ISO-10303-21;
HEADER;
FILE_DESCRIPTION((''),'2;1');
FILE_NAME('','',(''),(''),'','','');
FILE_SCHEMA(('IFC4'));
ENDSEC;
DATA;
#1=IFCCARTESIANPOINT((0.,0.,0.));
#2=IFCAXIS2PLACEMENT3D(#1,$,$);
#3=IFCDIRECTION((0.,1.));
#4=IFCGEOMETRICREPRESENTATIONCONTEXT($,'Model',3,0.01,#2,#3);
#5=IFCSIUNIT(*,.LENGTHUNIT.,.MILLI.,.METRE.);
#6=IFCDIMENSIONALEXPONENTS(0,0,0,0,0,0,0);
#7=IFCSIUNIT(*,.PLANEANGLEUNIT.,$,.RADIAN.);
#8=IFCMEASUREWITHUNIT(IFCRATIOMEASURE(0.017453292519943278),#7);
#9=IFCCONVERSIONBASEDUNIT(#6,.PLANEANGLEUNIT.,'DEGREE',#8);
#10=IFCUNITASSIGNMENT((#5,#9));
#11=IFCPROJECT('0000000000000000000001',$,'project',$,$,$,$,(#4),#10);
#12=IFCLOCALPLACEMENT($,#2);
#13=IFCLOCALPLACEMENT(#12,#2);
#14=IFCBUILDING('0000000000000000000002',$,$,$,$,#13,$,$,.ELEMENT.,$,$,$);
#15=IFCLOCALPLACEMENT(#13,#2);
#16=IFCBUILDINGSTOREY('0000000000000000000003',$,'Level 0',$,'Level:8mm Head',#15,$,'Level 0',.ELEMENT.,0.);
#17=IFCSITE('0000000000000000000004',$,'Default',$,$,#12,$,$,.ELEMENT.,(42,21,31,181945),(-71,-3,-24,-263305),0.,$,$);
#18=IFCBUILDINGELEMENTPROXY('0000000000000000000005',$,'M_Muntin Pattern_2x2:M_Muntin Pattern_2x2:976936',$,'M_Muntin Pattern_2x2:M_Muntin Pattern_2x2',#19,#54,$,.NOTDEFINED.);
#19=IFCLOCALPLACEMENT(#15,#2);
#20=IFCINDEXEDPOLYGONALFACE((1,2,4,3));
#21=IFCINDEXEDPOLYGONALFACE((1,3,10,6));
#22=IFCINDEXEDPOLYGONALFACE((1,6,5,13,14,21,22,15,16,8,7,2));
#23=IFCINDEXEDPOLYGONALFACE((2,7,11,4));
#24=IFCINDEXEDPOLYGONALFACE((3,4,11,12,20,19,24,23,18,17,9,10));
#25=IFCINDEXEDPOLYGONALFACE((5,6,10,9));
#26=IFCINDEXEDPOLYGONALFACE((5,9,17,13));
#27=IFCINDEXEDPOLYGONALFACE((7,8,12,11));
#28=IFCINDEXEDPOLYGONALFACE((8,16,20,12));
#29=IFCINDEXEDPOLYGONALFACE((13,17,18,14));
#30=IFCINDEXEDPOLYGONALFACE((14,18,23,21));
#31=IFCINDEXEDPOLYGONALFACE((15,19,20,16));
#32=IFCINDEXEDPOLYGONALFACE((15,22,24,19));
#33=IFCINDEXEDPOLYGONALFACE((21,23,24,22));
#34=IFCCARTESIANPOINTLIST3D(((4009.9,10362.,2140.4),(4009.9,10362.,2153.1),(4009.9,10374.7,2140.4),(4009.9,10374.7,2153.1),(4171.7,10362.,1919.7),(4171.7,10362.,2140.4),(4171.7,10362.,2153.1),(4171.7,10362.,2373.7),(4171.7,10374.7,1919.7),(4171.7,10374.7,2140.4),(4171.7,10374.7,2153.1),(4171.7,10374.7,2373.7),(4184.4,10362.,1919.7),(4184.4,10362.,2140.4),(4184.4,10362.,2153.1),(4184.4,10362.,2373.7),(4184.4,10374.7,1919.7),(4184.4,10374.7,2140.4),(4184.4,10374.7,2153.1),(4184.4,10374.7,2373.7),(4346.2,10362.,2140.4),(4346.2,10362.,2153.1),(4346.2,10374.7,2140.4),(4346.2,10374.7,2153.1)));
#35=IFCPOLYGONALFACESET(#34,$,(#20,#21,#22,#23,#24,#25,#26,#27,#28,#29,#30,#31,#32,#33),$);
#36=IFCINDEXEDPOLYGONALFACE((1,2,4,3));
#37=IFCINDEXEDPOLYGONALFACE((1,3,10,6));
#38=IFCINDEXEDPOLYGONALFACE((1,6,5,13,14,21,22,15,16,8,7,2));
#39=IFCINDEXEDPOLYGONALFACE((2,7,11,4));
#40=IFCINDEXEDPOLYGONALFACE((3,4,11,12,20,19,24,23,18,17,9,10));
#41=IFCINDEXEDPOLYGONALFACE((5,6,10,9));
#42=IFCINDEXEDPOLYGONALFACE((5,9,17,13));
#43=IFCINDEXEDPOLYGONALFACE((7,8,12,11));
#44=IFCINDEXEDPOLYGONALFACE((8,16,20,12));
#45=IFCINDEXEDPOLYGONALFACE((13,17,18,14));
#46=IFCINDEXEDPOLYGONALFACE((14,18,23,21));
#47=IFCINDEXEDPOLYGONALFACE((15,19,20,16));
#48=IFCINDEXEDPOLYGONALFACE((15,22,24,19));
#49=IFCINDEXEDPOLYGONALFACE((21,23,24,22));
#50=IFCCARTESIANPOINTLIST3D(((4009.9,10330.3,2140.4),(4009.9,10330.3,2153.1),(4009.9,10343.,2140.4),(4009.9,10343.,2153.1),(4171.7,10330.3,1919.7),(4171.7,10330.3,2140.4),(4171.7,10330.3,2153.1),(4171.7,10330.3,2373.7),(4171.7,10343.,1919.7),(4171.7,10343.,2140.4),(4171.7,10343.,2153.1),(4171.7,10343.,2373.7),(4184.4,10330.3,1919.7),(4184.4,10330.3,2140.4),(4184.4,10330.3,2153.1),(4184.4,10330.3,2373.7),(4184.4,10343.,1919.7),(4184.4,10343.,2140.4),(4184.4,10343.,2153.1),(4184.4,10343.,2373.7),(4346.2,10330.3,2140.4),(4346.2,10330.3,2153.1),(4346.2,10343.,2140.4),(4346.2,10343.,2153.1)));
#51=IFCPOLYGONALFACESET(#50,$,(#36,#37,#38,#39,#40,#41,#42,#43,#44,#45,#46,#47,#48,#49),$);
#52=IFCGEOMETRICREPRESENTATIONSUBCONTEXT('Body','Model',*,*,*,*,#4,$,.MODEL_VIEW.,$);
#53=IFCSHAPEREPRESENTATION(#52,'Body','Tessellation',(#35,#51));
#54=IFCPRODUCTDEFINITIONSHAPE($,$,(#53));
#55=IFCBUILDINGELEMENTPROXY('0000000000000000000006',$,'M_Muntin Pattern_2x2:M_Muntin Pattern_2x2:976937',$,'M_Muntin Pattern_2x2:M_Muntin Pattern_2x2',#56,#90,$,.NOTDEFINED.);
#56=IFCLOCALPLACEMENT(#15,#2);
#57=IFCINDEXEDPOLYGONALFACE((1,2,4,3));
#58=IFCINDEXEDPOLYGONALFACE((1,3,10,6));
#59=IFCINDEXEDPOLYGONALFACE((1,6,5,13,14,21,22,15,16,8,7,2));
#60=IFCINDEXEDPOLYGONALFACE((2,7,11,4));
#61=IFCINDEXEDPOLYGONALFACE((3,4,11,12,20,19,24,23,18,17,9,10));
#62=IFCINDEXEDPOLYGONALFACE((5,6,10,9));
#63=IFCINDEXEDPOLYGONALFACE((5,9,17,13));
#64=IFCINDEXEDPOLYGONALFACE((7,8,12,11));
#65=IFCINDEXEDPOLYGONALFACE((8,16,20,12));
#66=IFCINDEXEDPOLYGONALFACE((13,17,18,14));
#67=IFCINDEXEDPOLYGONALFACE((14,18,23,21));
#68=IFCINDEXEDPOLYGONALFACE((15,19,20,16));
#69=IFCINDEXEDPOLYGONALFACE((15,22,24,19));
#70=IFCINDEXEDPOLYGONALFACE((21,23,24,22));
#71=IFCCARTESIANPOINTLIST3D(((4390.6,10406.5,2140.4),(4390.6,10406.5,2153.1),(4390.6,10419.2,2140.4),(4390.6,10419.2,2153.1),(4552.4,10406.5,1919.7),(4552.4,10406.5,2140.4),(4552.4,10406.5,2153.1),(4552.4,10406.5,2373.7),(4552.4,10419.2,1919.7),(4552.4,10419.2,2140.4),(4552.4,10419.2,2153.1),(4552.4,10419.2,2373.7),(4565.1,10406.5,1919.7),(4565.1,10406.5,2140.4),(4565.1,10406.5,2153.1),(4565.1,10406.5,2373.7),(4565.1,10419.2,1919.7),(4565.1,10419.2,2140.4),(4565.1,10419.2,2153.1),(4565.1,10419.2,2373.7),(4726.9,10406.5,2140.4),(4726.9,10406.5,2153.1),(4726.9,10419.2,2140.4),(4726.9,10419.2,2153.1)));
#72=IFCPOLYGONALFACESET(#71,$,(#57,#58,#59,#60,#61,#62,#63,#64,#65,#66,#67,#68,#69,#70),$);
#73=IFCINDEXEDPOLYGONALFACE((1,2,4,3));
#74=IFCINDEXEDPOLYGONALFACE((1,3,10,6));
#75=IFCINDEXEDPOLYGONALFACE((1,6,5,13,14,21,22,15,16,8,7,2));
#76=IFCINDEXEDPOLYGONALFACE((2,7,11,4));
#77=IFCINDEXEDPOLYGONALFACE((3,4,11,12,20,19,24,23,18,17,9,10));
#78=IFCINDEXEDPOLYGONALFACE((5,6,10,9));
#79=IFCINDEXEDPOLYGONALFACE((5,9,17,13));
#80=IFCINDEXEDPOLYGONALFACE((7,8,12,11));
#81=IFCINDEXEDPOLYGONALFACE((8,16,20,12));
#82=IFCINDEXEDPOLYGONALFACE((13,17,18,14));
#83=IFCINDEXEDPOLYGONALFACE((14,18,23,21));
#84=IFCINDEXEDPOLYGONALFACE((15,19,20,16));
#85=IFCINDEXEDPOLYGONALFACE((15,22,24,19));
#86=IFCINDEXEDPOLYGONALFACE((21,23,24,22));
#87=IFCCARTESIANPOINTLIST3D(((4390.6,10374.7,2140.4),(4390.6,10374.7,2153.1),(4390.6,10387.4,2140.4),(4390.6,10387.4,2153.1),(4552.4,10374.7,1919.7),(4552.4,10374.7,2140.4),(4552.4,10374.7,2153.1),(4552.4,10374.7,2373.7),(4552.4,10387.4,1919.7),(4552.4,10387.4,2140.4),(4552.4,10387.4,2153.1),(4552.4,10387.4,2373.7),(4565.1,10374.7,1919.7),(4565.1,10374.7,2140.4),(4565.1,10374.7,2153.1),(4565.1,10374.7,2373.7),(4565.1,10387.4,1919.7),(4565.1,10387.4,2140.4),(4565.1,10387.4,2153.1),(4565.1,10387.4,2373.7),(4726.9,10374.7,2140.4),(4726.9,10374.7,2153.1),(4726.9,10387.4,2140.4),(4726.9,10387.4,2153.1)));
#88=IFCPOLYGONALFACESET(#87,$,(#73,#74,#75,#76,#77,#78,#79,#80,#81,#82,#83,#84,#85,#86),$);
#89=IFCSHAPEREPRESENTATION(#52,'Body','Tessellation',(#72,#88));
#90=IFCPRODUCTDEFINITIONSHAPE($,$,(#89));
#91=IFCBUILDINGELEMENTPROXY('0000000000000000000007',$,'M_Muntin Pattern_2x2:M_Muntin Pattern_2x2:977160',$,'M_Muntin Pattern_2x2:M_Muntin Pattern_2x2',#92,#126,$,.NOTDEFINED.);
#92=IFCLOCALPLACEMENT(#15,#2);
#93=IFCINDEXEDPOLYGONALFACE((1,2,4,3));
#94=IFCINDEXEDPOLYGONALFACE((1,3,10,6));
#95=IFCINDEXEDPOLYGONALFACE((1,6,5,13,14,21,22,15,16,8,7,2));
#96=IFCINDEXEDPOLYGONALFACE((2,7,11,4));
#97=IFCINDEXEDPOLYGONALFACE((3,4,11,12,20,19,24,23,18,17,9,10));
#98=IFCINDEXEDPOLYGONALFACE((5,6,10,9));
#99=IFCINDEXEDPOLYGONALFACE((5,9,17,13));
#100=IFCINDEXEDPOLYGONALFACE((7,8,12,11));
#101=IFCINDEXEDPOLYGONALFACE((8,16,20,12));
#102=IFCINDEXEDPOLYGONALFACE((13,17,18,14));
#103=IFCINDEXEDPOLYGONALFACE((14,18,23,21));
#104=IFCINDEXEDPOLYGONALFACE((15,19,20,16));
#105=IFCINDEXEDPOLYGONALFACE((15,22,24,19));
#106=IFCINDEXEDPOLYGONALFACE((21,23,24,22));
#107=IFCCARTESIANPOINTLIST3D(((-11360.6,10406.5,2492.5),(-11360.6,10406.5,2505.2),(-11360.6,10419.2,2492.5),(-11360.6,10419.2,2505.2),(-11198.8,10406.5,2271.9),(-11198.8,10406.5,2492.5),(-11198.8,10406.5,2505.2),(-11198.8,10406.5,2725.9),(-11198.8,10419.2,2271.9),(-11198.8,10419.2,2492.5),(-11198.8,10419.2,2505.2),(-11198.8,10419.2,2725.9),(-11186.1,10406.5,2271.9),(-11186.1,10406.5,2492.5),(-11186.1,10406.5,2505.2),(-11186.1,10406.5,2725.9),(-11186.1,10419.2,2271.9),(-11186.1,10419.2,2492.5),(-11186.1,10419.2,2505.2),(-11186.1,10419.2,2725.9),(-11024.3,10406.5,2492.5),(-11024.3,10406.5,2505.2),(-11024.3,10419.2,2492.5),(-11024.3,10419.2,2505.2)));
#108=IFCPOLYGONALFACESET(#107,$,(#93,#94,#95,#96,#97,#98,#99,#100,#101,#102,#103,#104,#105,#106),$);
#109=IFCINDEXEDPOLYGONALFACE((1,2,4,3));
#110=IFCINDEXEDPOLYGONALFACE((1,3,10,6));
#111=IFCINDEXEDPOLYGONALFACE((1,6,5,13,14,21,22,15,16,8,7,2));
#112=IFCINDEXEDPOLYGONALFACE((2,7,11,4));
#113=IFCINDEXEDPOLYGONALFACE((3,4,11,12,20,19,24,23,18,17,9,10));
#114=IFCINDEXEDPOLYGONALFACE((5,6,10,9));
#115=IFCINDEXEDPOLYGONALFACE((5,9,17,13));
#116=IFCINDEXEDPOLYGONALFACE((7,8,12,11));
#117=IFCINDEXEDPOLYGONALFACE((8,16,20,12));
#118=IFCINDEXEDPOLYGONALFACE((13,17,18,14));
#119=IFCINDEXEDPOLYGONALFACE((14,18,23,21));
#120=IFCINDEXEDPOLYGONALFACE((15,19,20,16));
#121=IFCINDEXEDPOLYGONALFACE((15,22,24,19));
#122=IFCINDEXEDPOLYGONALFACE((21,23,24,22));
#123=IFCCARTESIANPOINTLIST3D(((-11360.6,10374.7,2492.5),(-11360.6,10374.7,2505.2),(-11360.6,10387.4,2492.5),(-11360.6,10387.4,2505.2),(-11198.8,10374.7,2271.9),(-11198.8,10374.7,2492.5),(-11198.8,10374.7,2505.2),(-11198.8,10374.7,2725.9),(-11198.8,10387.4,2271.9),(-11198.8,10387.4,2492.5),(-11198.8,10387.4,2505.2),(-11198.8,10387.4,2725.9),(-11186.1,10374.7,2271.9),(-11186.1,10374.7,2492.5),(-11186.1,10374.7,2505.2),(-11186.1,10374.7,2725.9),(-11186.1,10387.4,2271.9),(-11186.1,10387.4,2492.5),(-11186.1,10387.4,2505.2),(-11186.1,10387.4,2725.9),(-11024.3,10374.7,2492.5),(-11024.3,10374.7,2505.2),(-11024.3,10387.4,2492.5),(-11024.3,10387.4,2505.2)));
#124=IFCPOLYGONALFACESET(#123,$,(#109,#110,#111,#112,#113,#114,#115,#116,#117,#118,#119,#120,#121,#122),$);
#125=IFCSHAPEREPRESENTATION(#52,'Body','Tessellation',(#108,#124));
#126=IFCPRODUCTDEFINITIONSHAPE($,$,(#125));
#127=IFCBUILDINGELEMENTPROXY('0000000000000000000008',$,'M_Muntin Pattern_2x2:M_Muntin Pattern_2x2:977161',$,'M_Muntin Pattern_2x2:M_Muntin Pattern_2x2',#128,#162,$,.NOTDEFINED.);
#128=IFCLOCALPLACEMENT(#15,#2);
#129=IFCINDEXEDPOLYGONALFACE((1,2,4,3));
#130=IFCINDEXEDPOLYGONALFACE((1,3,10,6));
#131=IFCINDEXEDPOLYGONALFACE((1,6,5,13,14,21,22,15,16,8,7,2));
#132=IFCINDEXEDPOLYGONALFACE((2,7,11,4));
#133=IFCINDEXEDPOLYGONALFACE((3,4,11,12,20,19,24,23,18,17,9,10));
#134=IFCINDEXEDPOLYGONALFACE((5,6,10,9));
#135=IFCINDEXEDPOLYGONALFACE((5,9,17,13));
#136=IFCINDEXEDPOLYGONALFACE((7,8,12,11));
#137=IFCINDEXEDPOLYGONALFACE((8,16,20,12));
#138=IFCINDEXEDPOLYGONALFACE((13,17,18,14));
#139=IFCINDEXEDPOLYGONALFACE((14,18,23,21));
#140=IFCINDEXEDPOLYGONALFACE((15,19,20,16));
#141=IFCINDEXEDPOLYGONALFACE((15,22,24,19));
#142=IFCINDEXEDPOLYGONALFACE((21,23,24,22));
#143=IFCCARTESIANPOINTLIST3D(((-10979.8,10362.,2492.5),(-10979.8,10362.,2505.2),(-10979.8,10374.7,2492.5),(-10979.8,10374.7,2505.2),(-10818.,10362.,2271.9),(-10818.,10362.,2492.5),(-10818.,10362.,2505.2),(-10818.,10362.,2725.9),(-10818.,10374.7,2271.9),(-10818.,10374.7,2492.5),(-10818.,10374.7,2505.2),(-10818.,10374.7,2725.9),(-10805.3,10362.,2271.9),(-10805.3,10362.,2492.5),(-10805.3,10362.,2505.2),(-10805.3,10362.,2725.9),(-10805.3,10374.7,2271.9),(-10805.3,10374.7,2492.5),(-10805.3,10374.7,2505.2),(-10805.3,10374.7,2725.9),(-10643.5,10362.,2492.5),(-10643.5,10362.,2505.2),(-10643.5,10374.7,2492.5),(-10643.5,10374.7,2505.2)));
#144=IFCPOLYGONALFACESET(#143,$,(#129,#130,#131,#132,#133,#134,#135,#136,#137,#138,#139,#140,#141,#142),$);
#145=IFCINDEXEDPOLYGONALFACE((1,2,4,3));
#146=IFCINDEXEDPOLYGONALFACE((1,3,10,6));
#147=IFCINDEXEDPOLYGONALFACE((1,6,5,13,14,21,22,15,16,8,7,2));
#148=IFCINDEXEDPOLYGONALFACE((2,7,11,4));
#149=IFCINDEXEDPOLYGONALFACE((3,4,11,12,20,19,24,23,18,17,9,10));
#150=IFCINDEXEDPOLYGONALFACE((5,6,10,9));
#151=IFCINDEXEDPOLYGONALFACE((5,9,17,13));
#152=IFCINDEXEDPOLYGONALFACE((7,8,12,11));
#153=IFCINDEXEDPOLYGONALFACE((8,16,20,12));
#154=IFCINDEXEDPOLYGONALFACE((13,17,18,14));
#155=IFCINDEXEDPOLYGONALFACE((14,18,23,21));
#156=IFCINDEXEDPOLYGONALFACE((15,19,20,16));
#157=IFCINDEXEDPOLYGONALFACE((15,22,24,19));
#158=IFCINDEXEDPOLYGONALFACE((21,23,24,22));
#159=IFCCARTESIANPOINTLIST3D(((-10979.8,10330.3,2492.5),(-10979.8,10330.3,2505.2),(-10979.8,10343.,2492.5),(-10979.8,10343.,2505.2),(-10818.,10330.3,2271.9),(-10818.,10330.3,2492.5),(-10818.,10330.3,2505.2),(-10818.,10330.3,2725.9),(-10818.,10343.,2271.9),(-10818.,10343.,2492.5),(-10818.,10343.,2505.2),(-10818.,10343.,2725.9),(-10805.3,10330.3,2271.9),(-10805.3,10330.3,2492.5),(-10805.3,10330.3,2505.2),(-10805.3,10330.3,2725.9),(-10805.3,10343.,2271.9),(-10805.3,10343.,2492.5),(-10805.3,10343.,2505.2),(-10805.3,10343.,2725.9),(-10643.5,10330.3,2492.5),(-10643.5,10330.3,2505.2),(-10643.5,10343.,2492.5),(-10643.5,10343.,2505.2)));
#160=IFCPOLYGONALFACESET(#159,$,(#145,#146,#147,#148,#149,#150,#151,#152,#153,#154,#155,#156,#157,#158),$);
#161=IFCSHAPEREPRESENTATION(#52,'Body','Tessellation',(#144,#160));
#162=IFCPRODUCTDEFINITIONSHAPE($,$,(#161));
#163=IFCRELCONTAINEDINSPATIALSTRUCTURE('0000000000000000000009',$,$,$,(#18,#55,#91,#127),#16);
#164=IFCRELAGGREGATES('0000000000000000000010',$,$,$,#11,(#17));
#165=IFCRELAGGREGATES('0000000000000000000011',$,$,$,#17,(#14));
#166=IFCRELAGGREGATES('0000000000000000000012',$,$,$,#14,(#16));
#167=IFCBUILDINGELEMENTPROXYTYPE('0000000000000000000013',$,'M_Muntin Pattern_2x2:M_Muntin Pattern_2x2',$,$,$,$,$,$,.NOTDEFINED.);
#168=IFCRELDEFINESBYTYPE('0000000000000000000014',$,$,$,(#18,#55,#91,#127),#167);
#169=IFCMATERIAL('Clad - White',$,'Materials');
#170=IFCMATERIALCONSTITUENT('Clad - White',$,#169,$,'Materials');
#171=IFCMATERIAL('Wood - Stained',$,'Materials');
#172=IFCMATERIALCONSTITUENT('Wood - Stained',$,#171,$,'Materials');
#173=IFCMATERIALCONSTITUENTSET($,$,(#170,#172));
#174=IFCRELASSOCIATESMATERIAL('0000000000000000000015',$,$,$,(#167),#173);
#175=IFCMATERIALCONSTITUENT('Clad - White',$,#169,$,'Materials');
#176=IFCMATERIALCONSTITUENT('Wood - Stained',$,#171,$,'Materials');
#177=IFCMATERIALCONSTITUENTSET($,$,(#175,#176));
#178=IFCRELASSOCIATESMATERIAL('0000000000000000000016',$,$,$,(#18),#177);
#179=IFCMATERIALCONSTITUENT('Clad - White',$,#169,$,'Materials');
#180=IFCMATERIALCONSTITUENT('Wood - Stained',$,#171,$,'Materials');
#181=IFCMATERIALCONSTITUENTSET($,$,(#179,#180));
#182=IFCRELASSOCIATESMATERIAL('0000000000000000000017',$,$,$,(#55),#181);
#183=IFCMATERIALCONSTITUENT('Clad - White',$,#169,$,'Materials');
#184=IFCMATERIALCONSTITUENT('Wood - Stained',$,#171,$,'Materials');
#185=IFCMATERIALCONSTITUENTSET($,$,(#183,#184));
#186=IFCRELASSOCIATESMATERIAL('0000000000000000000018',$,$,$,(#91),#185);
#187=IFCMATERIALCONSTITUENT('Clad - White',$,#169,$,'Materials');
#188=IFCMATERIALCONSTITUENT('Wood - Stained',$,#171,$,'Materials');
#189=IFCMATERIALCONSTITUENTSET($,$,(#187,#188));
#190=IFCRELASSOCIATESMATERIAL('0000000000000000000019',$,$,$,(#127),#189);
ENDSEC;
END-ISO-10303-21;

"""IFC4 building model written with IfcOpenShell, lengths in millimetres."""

from ifc_helpers import new_model, entity, si_unit, converted_unit, direction, frame, origin, place, context, subcontext, project, spatial, polyline, outline, extrude, source, transform, mapped, material, constituent, constituent_set, type_object, type_shapes, element, save


model = new_model("IFC4")

# Units and contexts
model_context = context("Model", 3, precision=0.01, world=origin(), true_north=direction((0.0, 1.0)))
body_context = subcontext(model_context, "Body", "Model", "MODEL_VIEW")
ifc_project = project(units=[si_unit("LENGTHUNIT", "METRE", prefix="MILLI"), converted_unit("PLANEANGLEUNIT", "DEGREE", entity("IfcRatioMeasure", 0.017453292519943278), si_unit("PLANEANGLEUNIT", "RADIAN"), dimensions=[0, 0, 0, 0, 0, 0, 0])], contexts=[model_context])

# Site, building, storey
site_placement = place(None, origin())
site = spatial("IfcSite", under=ifc_project, at=site_placement, Name="Default", CompositionType="ELEMENT", RefLatitude=(42, 21, 31, 181945), RefLongitude=(-71, -3, -24, -263305), RefElevation=0.0)
building_placement = place(site_placement, origin())
building = spatial("IfcBuilding", under=site, at=building_placement, CompositionType="ELEMENT")
storey_placement = place(building_placement, origin())
storey = spatial("IfcBuildingStorey", under=building, at=storey_placement, Name="Level 0", ObjectType="Level:8mm Head", LongName="Level 0", CompositionType="ELEMENT", Elevation=0.0)

# Building element proxies
ifc_material_1 = material(Name="Clad - White", Category="Materials")
ifc_material_2 = material(Name="Wood - Stained", Category="Materials")
ifc_constituent_1 = constituent(ifc_material_1, Name="Clad - White", Category="Materials")
ifc_constituent_2 = constituent(ifc_material_2, Name="Wood - Stained", Category="Materials")
ifc_constituent_set_1 = constituent_set(constituents=[ifc_constituent_1, ifc_constituent_2])
building_element_proxy_type_1 = type_object("IfcBuildingElementProxyType", Name="M_Muntin Pattern_2x2:M_Muntin Pattern_2x2", PredefinedType="NOTDEFINED", material=ifc_constituent_set_1)
shared_shape_1 = source(origin(), body_context, "Body", "SweptSolid", [
    extrude(outline(polyline([(6.4, -6.4), (227.0, -6.4), (227.0, 6.3), (6.4, 6.3), (6.4, 168.2), (-6.3, 168.2), (-6.3, 6.3), (-227.0, 6.3), (-227.0, -6.4), (-6.3, -6.4), (-6.3, -168.1), (6.4, -168.1), (6.4, -6.4)])), frame((0.0, 9.5, 227.0), z_axis=(0.0, 1.0, 0.0), x_axis=(0.0, 0.0, 1.0)), (0.0, 0.0, 1.0), 12.7),
    extrude(outline(polyline([(6.4, -6.4), (227.0, -6.4), (227.0, 6.3), (6.4, 6.3), (6.4, 168.2), (-6.3, 168.2), (-6.3, 6.3), (-227.0, 6.3), (-227.0, -6.4), (-6.3, -6.4), (-6.3, -168.1), (6.4, -168.1), (6.4, -6.4)])), frame((0.0, -22.2, 227.0), z_axis=(0.0, 1.0, 0.0), x_axis=(0.0, 0.0, 1.0)), (0.0, 0.0, 1.0), 12.7),
])
type_shapes(building_element_proxy_type_1, [shared_shape_1])
ifc_constituent_3 = constituent(ifc_material_1, Name="Clad - White", Category="Materials")
ifc_constituent_4 = constituent(ifc_material_2, Name="Wood - Stained", Category="Materials")
ifc_constituent_set_2 = constituent_set(constituents=[ifc_constituent_3, ifc_constituent_4])
proxy_1_placement = place(storey_placement, frame((4178.0, 10352.5, 1919.7)))
element("IfcBuildingElementProxy", 1, at=proxy_1_placement, inside=storey, type_object=building_element_proxy_type_1, material=ifc_constituent_set_2, Name="M_Muntin Pattern_2x2:M_Muntin Pattern_2x2:976936", ObjectType="M_Muntin Pattern_2x2:M_Muntin Pattern_2x2", PredefinedType="NOTDEFINED", context=body_context, shape_type="MappedRepresentation", body=[
    mapped(shared_shape_1, transform((0.0, 0.0, 0.0), scale=1.0)),
])
ifc_constituent_5 = constituent(ifc_material_1, Name="Clad - White", Category="Materials")
ifc_constituent_6 = constituent(ifc_material_2, Name="Wood - Stained", Category="Materials")
ifc_constituent_set_3 = constituent_set(constituents=[ifc_constituent_5, ifc_constituent_6])
proxy_2_placement = place(storey_placement, frame((4558.8, 10396.9, 1919.7)))
element("IfcBuildingElementProxy", 2, at=proxy_2_placement, inside=storey, type_object=building_element_proxy_type_1, material=ifc_constituent_set_3, Name="M_Muntin Pattern_2x2:M_Muntin Pattern_2x2:976937", ObjectType="M_Muntin Pattern_2x2:M_Muntin Pattern_2x2", PredefinedType="NOTDEFINED", context=body_context, shape_type="MappedRepresentation", body=[
    mapped(shared_shape_1, transform((0.0, 0.0, 0.0), scale=1.0)),
])
ifc_constituent_7 = constituent(ifc_material_1, Name="Clad - White", Category="Materials")
ifc_constituent_8 = constituent(ifc_material_2, Name="Wood - Stained", Category="Materials")
ifc_constituent_set_4 = constituent_set(constituents=[ifc_constituent_7, ifc_constituent_8])
proxy_3_placement = place(storey_placement, frame((-11192.4, 10396.9, 2271.9)))
element("IfcBuildingElementProxy", 3, at=proxy_3_placement, inside=storey, type_object=building_element_proxy_type_1, material=ifc_constituent_set_4, Name="M_Muntin Pattern_2x2:M_Muntin Pattern_2x2:977160", ObjectType="M_Muntin Pattern_2x2:M_Muntin Pattern_2x2", PredefinedType="NOTDEFINED", context=body_context, shape_type="MappedRepresentation", body=[
    mapped(shared_shape_1, transform((0.0, 0.0, 0.0), scale=1.0)),
])
ifc_constituent_9 = constituent(ifc_material_1, Name="Clad - White", Category="Materials")
ifc_constituent_10 = constituent(ifc_material_2, Name="Wood - Stained", Category="Materials")
ifc_constituent_set_5 = constituent_set(constituents=[ifc_constituent_9, ifc_constituent_10])
proxy_4_placement = place(storey_placement, frame((-10811.7, 10352.5, 2271.9)))
element("IfcBuildingElementProxy", 4, at=proxy_4_placement, inside=storey, type_object=building_element_proxy_type_1, material=ifc_constituent_set_5, Name="M_Muntin Pattern_2x2:M_Muntin Pattern_2x2:977161", ObjectType="M_Muntin Pattern_2x2:M_Muntin Pattern_2x2", PredefinedType="NOTDEFINED", context=body_context, shape_type="MappedRepresentation", body=[
    mapped(shared_shape_1, transform((0.0, 0.0, 0.0), scale=1.0)),
])

save(model, "model.ifc")
